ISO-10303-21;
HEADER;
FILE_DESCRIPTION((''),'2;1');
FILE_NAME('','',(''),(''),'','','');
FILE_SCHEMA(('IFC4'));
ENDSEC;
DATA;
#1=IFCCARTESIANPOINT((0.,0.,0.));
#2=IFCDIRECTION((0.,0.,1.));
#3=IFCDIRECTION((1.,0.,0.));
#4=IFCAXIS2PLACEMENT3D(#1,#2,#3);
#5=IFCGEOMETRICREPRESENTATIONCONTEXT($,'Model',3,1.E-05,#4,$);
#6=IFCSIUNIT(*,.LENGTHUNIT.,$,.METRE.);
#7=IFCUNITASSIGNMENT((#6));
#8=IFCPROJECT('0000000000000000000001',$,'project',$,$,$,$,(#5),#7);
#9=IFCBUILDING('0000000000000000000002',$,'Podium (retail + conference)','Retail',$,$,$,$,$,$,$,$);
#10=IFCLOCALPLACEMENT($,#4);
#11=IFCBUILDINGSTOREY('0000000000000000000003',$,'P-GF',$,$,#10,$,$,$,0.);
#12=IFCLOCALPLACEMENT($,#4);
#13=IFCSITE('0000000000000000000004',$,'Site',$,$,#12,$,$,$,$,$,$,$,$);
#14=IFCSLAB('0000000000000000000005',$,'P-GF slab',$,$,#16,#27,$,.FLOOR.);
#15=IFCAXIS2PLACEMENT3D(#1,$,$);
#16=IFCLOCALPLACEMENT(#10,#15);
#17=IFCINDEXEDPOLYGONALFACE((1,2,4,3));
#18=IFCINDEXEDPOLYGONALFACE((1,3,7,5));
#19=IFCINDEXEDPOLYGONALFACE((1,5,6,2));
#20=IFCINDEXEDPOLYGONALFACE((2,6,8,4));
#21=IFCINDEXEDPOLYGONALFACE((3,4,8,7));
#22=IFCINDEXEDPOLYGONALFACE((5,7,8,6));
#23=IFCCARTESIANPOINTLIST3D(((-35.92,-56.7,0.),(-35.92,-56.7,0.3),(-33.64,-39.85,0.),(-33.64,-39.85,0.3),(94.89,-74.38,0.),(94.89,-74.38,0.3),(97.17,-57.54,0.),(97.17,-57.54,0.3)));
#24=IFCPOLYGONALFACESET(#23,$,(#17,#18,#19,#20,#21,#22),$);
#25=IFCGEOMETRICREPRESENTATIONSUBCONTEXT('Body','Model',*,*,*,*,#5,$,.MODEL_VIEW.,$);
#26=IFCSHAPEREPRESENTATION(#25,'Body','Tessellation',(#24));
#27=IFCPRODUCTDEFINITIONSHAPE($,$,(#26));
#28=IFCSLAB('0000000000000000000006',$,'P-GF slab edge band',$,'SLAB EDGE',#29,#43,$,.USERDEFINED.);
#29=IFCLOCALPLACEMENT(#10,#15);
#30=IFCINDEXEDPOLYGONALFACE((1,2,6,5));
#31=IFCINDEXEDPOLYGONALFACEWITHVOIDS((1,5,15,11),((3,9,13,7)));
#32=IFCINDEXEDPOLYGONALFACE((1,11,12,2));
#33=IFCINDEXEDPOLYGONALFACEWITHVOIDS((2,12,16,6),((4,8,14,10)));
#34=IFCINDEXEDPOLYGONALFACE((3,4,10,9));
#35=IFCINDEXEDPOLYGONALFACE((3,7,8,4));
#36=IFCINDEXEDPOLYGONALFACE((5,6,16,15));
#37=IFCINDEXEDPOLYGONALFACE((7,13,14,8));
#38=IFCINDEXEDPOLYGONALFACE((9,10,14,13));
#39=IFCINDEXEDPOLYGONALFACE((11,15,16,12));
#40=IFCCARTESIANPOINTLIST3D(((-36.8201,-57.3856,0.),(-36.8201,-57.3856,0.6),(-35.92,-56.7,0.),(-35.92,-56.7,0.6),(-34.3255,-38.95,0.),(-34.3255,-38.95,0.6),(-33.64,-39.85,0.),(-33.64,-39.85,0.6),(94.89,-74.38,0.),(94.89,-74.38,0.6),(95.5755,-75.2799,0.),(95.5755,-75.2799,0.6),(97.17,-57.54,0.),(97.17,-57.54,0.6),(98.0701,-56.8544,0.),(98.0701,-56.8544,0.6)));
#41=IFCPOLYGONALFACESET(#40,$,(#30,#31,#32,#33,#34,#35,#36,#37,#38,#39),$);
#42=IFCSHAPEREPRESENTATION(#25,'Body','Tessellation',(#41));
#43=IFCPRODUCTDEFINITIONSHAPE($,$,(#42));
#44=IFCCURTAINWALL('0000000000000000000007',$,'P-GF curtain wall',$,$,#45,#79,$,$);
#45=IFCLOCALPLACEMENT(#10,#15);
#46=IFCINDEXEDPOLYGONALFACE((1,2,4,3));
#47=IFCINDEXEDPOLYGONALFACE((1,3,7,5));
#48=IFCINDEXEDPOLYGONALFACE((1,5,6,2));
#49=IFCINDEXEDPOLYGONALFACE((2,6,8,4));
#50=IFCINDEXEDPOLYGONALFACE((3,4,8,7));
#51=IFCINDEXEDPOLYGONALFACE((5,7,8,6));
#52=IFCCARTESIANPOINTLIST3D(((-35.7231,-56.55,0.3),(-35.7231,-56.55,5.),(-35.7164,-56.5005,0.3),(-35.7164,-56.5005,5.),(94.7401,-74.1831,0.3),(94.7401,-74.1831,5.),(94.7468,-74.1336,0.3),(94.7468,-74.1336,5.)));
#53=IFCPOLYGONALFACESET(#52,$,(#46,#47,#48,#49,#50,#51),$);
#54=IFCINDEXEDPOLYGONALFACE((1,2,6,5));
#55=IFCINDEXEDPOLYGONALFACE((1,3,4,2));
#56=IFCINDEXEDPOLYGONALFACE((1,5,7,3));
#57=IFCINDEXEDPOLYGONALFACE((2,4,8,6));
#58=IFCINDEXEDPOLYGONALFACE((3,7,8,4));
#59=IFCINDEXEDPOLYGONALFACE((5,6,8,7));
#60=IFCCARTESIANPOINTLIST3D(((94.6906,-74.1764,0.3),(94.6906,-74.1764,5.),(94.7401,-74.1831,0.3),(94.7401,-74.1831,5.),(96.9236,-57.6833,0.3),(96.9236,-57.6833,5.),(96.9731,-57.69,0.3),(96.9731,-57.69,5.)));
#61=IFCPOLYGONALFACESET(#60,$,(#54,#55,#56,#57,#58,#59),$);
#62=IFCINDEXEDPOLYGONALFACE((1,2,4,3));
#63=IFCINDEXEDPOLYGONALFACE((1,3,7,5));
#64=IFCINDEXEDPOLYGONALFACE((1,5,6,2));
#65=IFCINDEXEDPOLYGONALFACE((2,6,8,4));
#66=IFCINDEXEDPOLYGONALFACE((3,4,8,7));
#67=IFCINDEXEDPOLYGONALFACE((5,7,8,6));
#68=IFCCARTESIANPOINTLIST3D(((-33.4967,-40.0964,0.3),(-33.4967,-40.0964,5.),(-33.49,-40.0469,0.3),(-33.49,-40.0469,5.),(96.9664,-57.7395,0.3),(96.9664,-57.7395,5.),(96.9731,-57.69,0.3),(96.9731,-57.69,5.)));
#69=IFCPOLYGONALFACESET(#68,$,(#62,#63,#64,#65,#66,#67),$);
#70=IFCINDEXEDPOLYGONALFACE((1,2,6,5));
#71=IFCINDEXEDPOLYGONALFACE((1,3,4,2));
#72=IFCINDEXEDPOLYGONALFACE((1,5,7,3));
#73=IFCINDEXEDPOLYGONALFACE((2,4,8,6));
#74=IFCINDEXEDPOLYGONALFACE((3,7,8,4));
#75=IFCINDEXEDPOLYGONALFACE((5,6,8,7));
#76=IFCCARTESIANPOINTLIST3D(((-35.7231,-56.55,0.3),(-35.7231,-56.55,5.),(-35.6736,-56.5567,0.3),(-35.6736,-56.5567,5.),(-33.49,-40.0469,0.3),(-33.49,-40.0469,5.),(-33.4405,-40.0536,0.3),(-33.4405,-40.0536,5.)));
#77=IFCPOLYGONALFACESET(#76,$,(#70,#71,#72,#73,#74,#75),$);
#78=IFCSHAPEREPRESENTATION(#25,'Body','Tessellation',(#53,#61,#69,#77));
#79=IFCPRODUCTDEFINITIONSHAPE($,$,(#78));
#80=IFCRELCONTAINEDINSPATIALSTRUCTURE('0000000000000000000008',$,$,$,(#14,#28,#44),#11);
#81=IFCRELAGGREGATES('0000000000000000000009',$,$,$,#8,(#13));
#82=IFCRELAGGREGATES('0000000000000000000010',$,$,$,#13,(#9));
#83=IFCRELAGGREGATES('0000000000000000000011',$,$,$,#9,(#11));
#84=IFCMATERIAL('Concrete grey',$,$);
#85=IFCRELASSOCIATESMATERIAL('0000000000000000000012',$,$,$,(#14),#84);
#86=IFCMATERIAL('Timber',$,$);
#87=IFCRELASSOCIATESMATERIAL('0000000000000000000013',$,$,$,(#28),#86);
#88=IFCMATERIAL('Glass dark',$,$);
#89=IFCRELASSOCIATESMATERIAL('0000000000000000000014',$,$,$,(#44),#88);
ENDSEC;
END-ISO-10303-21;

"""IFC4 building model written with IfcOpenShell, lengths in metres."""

from ifc_helpers import new_model, si_unit, frame, origin_with_axes, place, context, subcontext, project, spatial, polyline, outline, extrude, material, element, save


model = new_model("IFC4")

# Units and contexts
model_context = context("Model", 3, precision=1e-05, world=origin_with_axes())
body_context = subcontext(model_context, "Body", "Model", "MODEL_VIEW")
ifc_project = project(units=[si_unit("LENGTHUNIT", "METRE")], contexts=[model_context])

# Site, building, storey
site_placement = place(None, origin_with_axes())
site = spatial("IfcSite", under=ifc_project, at=site_placement, Name="Site")
building = spatial("IfcBuilding", under=site, Name="Podium (retail + conference)", Description="Retail")
storey_placement = place(None, origin_with_axes())
storey = spatial("IfcBuildingStorey", under=building, at=storey_placement, Name="P-GF", Elevation=0.0)

# Slabs
ifc_material_1 = material(Name="Concrete grey")
slab_1_placement = place(storey_placement, origin_with_axes())
element("IfcSlab", 1, at=slab_1_placement, inside=storey, material=ifc_material_1, Name="P-GF slab", PredefinedType="FLOOR", context=body_context, shape_type="SweptSolid", body=[
    extrude(outline(polyline([(-35.92, -56.7), (94.89, -74.38), (97.17, -57.54), (-33.64, -39.85), (-35.92, -56.7)])), origin_with_axes(), (0.0, 0.0, 1.0), 0.3),
])
ifc_material_2 = material(Name="Timber")
slab_2_placement = place(storey_placement, origin_with_axes())
element("IfcSlab", 2, at=slab_2_placement, inside=storey, material=ifc_material_2, Name="P-GF slab edge band", ObjectType="SLAB EDGE", PredefinedType="USERDEFINED", context=body_context, shape_type="SweptSolid", body=[
    extrude(outline(polyline([(-36.8201, -57.3856), (95.5755, -75.2799), (98.0701, -56.8544), (-34.3255, -38.95), (-36.8201, -57.3856)]), holes=[polyline([(-35.92, -56.7), (94.89, -74.38), (97.17, -57.54), (-33.64, -39.85), (-35.92, -56.7)])]), origin_with_axes(), (0.0, 0.0, 1.0), 0.6),
])

# Curtain wall
ifc_material_3 = material(Name="Glass dark")
curtain_wall_placement = place(storey_placement, origin_with_axes())
element("IfcCurtainWall", 3, at=curtain_wall_placement, inside=storey, material=ifc_material_3, Name="P-GF curtain wall", context=body_context, shape_type="SweptSolid", body=[
    extrude(outline(polyline([(-35.7231, -56.55), (94.7401, -74.1831), (94.7468, -74.1336), (-35.7164, -56.5005), (-35.7231, -56.55)])), frame((0.0, 0.0, 0.3), z_axis=(0.0, 0.0, 1.0), x_axis=(1.0, 0.0, 0.0)), (0.0, 0.0, 1.0), 4.7),
    extrude(outline(polyline([(94.7401, -74.1831), (96.9731, -57.69), (96.9236, -57.6833), (94.6906, -74.1764), (94.7401, -74.1831)])), frame((0.0, 0.0, 0.3), z_axis=(0.0, 0.0, 1.0), x_axis=(1.0, 0.0, 0.0)), (0.0, 0.0, 1.0), 4.7),
    extrude(outline(polyline([(96.9731, -57.69), (-33.49, -40.0469), (-33.4967, -40.0964), (96.9664, -57.7395), (96.9731, -57.69)])), frame((0.0, 0.0, 0.3), z_axis=(0.0, 0.0, 1.0), x_axis=(1.0, 0.0, 0.0)), (0.0, 0.0, 1.0), 4.7),
    extrude(outline(polyline([(-33.49, -40.0469), (-35.7231, -56.55), (-35.6736, -56.5567), (-33.4405, -40.0536), (-33.49, -40.0469)])), frame((0.0, 0.0, 0.3), z_axis=(0.0, 0.0, 1.0), x_axis=(1.0, 0.0, 0.0)), (0.0, 0.0, 1.0), 4.7),
])

save(model, "model.ifc")
